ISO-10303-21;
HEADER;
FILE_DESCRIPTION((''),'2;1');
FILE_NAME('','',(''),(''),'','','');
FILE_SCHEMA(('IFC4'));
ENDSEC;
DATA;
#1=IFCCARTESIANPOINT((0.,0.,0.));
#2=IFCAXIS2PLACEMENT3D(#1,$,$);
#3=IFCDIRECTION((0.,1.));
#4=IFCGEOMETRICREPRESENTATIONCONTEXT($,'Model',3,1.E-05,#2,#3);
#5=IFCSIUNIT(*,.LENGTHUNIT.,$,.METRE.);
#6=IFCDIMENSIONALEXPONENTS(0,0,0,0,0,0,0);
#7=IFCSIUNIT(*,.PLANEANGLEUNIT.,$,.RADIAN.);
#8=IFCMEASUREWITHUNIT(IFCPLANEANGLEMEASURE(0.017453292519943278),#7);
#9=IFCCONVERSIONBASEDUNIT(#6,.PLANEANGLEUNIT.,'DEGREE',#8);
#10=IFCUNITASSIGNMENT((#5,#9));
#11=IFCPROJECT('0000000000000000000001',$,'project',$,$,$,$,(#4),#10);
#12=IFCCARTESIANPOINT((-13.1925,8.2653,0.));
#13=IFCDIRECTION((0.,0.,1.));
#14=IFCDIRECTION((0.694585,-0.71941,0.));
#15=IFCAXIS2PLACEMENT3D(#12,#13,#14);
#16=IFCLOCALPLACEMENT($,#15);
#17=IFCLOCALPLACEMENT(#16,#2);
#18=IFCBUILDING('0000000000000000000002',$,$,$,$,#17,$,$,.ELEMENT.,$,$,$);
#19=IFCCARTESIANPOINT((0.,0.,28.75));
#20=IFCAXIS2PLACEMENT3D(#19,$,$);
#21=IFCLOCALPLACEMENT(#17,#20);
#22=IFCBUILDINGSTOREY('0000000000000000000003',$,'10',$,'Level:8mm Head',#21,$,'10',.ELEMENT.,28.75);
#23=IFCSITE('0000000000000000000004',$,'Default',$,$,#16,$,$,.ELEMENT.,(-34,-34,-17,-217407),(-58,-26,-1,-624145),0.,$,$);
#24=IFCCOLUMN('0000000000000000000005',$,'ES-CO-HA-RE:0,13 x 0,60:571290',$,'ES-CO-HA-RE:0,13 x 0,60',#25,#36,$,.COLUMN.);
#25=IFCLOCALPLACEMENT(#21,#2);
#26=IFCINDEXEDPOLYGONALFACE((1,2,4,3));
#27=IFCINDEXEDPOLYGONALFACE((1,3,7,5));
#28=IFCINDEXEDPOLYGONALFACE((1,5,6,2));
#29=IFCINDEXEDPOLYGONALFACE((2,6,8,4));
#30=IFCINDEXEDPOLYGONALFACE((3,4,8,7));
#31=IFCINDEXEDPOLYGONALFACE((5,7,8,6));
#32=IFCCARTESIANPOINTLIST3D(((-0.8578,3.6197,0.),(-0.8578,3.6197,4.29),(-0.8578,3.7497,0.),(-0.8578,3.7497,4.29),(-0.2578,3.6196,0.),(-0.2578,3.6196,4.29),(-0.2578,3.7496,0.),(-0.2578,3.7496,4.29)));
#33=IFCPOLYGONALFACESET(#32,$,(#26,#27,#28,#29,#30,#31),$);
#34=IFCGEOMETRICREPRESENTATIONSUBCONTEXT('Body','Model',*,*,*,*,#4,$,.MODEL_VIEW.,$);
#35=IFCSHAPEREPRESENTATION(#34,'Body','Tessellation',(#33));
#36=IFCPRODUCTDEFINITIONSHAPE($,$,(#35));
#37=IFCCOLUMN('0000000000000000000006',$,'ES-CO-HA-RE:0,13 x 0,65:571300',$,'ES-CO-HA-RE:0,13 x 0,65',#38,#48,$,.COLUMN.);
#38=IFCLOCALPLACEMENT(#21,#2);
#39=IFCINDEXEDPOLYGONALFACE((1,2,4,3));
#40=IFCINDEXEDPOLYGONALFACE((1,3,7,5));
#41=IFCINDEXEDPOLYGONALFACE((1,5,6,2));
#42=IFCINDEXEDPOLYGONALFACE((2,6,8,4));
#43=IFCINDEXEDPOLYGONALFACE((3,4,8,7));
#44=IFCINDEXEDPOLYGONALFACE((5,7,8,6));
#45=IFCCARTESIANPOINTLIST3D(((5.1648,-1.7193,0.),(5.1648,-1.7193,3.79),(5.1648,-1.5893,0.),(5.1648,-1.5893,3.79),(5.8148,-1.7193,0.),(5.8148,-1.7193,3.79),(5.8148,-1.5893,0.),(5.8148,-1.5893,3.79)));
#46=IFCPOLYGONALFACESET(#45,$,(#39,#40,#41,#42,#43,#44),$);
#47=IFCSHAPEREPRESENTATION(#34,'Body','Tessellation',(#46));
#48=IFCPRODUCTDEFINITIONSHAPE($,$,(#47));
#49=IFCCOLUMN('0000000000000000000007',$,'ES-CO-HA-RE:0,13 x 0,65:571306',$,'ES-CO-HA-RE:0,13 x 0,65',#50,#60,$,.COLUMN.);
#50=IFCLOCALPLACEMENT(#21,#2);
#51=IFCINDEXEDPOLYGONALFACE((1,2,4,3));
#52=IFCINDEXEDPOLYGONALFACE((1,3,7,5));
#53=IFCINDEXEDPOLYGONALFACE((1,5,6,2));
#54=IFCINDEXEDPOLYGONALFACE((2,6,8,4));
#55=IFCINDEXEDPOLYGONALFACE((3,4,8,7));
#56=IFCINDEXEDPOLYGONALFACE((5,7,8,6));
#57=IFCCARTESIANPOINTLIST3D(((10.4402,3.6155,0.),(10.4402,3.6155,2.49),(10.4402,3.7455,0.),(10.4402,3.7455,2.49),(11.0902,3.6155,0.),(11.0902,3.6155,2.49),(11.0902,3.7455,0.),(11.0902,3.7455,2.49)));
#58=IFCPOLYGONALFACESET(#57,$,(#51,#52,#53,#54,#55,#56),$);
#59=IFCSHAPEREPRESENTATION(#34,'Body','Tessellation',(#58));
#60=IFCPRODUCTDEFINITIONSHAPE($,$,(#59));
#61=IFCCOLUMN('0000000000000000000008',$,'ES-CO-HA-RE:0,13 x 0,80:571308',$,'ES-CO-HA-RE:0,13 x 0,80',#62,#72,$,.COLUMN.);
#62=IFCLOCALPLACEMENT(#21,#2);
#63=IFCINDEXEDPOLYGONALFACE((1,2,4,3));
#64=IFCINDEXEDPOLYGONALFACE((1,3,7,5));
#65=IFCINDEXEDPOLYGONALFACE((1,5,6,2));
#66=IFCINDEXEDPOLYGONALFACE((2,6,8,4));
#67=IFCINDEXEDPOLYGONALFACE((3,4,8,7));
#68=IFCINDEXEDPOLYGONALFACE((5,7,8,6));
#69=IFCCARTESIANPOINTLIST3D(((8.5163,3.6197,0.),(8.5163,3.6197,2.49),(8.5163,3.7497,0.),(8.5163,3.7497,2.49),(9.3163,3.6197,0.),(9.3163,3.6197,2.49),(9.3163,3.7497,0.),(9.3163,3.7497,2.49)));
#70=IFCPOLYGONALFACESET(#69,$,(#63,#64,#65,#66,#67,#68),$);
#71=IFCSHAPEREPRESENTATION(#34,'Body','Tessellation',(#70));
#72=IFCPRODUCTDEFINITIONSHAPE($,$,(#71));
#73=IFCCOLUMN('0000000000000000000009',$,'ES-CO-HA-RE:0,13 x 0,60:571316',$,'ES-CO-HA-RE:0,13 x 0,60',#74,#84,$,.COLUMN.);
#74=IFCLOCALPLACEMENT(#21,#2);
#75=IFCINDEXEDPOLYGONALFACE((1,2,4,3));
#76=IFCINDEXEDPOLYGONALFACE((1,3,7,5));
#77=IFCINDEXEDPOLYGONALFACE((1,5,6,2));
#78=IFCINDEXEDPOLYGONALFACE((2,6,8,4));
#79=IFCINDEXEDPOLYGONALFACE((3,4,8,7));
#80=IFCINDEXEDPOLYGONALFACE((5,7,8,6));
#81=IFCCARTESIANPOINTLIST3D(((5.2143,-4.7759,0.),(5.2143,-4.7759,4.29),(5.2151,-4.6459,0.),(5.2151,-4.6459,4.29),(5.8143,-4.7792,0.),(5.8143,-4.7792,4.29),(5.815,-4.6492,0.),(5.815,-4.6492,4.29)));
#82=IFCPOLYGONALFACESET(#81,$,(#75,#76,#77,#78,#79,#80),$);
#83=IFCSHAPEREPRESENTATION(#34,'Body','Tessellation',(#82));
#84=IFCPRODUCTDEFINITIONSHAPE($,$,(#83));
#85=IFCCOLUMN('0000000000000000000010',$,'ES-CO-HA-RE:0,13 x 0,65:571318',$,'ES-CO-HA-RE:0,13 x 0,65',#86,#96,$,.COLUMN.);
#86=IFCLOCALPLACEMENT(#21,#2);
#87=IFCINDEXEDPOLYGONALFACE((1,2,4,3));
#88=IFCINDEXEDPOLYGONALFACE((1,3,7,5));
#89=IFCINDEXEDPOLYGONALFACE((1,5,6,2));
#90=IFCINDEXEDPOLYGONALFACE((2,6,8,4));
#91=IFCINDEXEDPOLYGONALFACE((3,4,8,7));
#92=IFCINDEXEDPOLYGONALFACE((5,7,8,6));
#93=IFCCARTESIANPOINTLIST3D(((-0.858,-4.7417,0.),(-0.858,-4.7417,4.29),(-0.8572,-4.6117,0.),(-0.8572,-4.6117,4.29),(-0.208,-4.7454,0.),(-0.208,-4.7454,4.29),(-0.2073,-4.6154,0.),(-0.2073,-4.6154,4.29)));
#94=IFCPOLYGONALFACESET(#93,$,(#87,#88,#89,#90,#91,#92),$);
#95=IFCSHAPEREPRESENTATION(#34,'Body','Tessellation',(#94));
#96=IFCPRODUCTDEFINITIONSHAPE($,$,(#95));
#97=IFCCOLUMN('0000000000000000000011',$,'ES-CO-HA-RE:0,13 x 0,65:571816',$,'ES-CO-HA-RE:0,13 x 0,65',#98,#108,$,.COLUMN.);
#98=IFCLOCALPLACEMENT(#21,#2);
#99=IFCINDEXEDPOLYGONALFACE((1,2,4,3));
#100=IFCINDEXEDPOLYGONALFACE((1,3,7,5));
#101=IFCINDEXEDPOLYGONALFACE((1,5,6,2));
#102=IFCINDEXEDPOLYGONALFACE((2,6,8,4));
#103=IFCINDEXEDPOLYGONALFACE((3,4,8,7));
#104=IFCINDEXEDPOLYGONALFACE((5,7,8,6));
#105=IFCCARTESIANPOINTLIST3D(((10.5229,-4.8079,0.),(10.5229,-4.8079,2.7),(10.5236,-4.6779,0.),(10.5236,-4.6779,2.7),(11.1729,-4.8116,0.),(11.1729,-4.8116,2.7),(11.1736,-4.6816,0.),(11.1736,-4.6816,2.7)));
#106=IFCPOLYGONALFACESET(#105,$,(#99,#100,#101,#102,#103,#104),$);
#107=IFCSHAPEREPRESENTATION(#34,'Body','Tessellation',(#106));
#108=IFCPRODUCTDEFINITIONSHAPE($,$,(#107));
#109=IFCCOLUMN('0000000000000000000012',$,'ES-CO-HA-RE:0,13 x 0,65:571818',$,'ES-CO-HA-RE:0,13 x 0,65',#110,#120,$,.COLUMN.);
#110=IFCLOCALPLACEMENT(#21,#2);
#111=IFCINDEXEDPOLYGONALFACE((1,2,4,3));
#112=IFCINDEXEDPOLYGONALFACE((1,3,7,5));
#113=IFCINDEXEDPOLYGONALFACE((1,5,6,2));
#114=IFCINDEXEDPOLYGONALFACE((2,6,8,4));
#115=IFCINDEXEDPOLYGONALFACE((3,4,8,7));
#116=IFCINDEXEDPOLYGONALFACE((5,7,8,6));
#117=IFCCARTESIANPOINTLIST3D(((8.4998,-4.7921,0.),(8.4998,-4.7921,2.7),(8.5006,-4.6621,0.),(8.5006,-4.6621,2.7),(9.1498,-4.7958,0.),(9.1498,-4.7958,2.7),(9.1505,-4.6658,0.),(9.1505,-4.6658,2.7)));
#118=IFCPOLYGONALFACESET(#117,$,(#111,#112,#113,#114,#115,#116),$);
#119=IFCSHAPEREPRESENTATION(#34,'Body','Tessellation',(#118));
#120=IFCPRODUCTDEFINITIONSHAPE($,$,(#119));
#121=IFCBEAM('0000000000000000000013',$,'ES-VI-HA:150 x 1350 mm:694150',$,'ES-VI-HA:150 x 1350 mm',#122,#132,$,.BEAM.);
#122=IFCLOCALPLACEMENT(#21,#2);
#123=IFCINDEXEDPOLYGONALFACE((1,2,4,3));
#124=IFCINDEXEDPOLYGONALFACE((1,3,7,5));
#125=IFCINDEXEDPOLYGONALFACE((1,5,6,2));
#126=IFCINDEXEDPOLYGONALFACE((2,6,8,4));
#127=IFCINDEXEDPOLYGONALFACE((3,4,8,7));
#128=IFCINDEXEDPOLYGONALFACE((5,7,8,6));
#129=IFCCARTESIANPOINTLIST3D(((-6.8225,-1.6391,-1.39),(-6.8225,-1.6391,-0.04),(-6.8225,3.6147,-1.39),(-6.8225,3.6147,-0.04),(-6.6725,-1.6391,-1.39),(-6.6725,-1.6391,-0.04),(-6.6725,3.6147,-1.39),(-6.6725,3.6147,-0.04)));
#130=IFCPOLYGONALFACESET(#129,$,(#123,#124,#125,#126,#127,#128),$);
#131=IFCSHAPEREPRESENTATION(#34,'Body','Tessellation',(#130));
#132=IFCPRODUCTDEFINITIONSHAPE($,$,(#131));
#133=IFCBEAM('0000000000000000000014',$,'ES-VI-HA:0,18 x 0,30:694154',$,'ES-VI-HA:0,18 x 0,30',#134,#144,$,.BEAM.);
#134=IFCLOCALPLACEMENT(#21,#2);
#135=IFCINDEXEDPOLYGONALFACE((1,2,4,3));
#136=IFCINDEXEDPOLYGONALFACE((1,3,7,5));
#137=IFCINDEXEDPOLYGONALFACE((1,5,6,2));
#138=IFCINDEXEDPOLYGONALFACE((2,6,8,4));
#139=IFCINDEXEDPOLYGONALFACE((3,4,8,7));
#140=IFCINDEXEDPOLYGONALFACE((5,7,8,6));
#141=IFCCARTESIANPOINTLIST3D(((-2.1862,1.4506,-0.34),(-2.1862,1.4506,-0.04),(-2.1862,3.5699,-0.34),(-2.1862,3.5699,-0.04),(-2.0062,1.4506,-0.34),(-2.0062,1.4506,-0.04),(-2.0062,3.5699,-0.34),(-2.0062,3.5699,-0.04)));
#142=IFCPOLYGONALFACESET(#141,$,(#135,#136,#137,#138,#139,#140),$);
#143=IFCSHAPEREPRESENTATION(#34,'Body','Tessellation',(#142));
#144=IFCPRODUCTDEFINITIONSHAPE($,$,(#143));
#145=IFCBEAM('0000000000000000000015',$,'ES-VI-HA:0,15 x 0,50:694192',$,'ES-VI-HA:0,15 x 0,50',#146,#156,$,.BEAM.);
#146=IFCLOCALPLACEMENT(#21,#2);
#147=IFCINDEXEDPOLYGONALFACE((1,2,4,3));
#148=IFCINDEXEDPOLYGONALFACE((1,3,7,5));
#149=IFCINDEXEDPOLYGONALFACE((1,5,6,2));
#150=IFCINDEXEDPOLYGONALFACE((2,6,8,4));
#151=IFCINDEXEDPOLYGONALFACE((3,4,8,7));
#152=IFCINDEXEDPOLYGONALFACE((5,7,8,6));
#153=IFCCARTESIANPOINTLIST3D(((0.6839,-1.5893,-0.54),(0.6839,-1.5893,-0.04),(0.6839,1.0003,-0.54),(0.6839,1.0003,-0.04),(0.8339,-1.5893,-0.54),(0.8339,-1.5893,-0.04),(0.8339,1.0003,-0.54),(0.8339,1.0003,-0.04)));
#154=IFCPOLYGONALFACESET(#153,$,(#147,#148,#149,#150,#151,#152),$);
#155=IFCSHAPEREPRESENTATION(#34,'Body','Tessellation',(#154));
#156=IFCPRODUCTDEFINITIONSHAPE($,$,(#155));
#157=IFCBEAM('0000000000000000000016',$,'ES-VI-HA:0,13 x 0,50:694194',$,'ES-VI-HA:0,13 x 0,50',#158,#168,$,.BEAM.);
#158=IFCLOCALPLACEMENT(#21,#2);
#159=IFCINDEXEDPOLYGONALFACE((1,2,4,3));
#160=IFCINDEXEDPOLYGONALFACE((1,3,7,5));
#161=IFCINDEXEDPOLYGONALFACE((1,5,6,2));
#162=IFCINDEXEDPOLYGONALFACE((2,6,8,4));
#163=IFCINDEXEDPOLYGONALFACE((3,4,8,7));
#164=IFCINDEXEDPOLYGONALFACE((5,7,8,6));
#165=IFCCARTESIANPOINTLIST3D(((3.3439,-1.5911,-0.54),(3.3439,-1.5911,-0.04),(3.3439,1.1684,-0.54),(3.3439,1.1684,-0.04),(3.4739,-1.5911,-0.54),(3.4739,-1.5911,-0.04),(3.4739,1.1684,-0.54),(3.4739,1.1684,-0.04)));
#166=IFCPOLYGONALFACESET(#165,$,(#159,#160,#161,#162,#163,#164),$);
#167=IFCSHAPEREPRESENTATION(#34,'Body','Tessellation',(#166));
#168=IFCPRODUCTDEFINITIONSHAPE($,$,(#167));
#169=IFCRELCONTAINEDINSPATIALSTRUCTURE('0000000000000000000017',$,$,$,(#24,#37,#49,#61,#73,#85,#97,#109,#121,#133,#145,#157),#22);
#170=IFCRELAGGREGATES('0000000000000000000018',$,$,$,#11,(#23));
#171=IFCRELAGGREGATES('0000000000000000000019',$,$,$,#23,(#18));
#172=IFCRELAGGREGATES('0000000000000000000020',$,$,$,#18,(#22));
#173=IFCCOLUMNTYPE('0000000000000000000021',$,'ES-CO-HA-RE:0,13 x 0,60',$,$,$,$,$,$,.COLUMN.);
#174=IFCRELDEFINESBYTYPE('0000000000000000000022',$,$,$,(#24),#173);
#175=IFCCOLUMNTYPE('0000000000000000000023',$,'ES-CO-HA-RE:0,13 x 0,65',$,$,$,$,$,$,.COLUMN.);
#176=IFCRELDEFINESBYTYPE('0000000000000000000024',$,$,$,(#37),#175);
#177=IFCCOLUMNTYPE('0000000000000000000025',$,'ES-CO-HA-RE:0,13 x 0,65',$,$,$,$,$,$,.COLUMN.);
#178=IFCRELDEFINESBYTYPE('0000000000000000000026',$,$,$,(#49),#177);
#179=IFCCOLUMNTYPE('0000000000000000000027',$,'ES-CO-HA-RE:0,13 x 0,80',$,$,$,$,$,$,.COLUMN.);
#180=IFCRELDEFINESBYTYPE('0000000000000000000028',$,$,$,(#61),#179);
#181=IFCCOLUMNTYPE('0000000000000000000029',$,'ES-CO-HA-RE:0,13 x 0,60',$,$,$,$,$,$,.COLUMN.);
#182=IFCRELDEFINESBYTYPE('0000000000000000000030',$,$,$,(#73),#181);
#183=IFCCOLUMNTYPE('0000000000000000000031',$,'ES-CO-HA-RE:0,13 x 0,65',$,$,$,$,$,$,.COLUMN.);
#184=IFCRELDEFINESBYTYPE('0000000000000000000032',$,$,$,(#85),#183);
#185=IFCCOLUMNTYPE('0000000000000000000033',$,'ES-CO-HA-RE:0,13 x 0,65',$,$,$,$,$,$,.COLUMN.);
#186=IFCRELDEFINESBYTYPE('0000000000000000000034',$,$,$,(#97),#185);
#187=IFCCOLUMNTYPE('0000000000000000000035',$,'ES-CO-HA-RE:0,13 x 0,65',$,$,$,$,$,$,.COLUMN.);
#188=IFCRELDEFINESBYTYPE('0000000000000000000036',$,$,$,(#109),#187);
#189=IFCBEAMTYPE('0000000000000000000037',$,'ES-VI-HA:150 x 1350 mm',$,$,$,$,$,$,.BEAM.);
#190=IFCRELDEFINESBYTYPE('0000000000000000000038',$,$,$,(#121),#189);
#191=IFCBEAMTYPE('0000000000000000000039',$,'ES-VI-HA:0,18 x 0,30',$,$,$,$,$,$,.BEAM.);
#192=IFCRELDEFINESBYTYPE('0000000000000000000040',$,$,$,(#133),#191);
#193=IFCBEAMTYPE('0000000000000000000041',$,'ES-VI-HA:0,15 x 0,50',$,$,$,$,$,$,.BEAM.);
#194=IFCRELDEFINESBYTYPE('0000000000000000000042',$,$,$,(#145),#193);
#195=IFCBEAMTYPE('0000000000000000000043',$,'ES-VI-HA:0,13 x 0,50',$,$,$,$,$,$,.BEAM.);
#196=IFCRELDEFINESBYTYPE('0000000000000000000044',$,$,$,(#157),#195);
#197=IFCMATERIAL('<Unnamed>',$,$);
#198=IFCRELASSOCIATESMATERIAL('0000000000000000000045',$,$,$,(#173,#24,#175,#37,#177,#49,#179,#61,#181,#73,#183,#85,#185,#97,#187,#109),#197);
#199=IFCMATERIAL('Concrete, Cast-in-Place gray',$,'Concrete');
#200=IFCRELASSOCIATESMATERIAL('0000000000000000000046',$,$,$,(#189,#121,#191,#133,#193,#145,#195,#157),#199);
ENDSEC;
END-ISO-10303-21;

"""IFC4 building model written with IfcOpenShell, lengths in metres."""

from ifc_helpers import new_model, entity, si_unit, converted_unit, direction, frame, origin, place, context, subcontext, project, spatial, indexed_curve, outline, extrude, source, transform, mapped, material, type_object, type_shapes, element, save


model = new_model("IFC4")

# Units and contexts
model_context = context("Model", 3, precision=1e-05, world=origin(), true_north=direction((0.0, 1.0)))
body_context = subcontext(model_context, "Body", "Model", "MODEL_VIEW")
ifc_project = project(units=[si_unit("LENGTHUNIT", "METRE"), converted_unit("PLANEANGLEUNIT", "DEGREE", entity("IfcPlaneAngleMeasure", 0.017453292519943278), si_unit("PLANEANGLEUNIT", "RADIAN"), dimensions=[0, 0, 0, 0, 0, 0, 0])], contexts=[model_context])

# Site, building, storey
site_placement = place(None, frame((-13.1925, 8.2653, 0.0), z_axis=(0.0, 0.0, 1.0), x_axis=(0.694585, -0.71941, 0.0)))
site = spatial("IfcSite", under=ifc_project, at=site_placement, Name="Default", CompositionType="ELEMENT", RefLatitude=(-34, -34, -17, -217407), RefLongitude=(-58, -26, -1, -624145), RefElevation=0.0)
building_placement = place(site_placement, origin())
building = spatial("IfcBuilding", under=site, at=building_placement, CompositionType="ELEMENT")
storey_placement = place(building_placement, frame((0.0, 0.0, 28.75)))
storey = spatial("IfcBuildingStorey", under=building, at=storey_placement, Name="10", ObjectType="Level:8mm Head", LongName="10", CompositionType="ELEMENT", Elevation=28.75)

# Columns
ifc_material_1 = material(Name="<Unnamed>")
column_type_1 = type_object("IfcColumnType", Name="ES-CO-HA-RE:0,13 x 0,60", PredefinedType="COLUMN", material=ifc_material_1)
shared_shape_1 = source(origin(), body_context, "Body", "SweptSolid", [
    extrude(outline(indexed_curve([(-0.3, -0.065), (0.3, -0.065), (0.3, 0.065), (-0.3, 0.065), (-0.3, -0.065)], self_intersect=False)), frame((-0.5578, 3.6847, 28.75), z_axis=(0.0, 0.0, 1.0), x_axis=(-1.0, 0.000006, 0.0)), (0.0, 0.0, 1.0), 4.29),
])
type_shapes(column_type_1, [shared_shape_1])
column_1_placement = place(storey_placement, frame((0.0, 0.0, -28.75)))
element("IfcColumn", 1, at=column_1_placement, inside=storey, type_object=column_type_1, material=ifc_material_1, Name="ES-CO-HA-RE:0,13 x 0,60:571290", ObjectType="ES-CO-HA-RE:0,13 x 0,60", PredefinedType="COLUMN", context=body_context, shape_type="MappedRepresentation", body=[
    mapped(shared_shape_1, transform((0.0, 0.0, 0.0), scale=1.0)),
])
column_type_2 = type_object("IfcColumnType", Name="ES-CO-HA-RE:0,13 x 0,65", PredefinedType="COLUMN", material=ifc_material_1)
shared_shape_2 = source(origin(), body_context, "Body", "SweptSolid", [
    extrude(outline(indexed_curve([(-0.325, -0.065), (0.325, -0.065), (0.325, 0.065), (-0.325, 0.065), (-0.325, -0.065)], self_intersect=False)), frame((5.4898, -1.6543, 28.75), z_axis=(0.0, 0.0, 1.0), x_axis=(-1.0, 0.0, 0.0)), (0.0, 0.0, 1.0), 3.79),
])
type_shapes(column_type_2, [shared_shape_2])
column_2_placement = place(storey_placement, frame((0.0, 0.0, -28.75)))
element("IfcColumn", 2, at=column_2_placement, inside=storey, type_object=column_type_2, material=ifc_material_1, Name="ES-CO-HA-RE:0,13 x 0,65:571300", ObjectType="ES-CO-HA-RE:0,13 x 0,65", PredefinedType="COLUMN", context=body_context, shape_type="MappedRepresentation", body=[
    mapped(shared_shape_2, transform((0.0, 0.0, 0.0), scale=1.0)),
])
column_type_3 = type_object("IfcColumnType", Name="ES-CO-HA-RE:0,13 x 0,65", PredefinedType="COLUMN", material=ifc_material_1)
shared_shape_3 = source(origin(), body_context, "Body", "SweptSolid", [
    extrude(outline(indexed_curve([(-0.325, -0.065), (0.325, -0.065), (0.325, 0.065), (-0.325, 0.065), (-0.325, -0.065)], self_intersect=False)), frame((10.7652, 3.6805, 28.75), z_axis=(0.0, 0.0, 1.0), x_axis=(-1.0, 0.0, 0.0)), (0.0, 0.0, 1.0), 2.49),
])
type_shapes(column_type_3, [shared_shape_3])
column_3_placement = place(storey_placement, frame((0.0, 0.0, -28.75)))
element("IfcColumn", 3, at=column_3_placement, inside=storey, type_object=column_type_3, material=ifc_material_1, Name="ES-CO-HA-RE:0,13 x 0,65:571306", ObjectType="ES-CO-HA-RE:0,13 x 0,65", PredefinedType="COLUMN", context=body_context, shape_type="MappedRepresentation", body=[
    mapped(shared_shape_3, transform((0.0, 0.0, 0.0), scale=1.0)),
])
column_type_4 = type_object("IfcColumnType", Name="ES-CO-HA-RE:0,13 x 0,80", PredefinedType="COLUMN", material=ifc_material_1)
shared_shape_4 = source(origin(), body_context, "Body", "SweptSolid", [
    extrude(outline(indexed_curve([(-0.4, -0.065), (0.4, -0.065), (0.4, 0.065), (-0.4, 0.065), (-0.4, -0.065)], self_intersect=False)), frame((8.9163, 3.6847, 28.75), z_axis=(0.0, 0.0, 1.0), x_axis=(-1.0, 0.0, 0.0)), (0.0, 0.0, 1.0), 2.49),
])
type_shapes(column_type_4, [shared_shape_4])
column_4_placement = place(storey_placement, frame((0.0, 0.0, -28.75)))
element("IfcColumn", 4, at=column_4_placement, inside=storey, type_object=column_type_4, material=ifc_material_1, Name="ES-CO-HA-RE:0,13 x 0,80:571308", ObjectType="ES-CO-HA-RE:0,13 x 0,80", PredefinedType="COLUMN", context=body_context, shape_type="MappedRepresentation", body=[
    mapped(shared_shape_4, transform((0.0, 0.0, 0.0), scale=1.0)),
])
column_type_5 = type_object("IfcColumnType", Name="ES-CO-HA-RE:0,13 x 0,60", PredefinedType="COLUMN", material=ifc_material_1)
shared_shape_5 = source(origin(), body_context, "Body", "SweptSolid", [
    extrude(outline(indexed_curve([(-0.3, -0.065), (0.3, -0.065), (0.3, 0.065), (-0.3, 0.065), (-0.3, -0.065)], self_intersect=False)), frame((5.5147, -4.7125, 28.75), z_axis=(0.0, 0.0, 1.0), x_axis=(-0.999984, 0.005619, 0.0)), (0.0, 0.0, 1.0), 4.29),
])
type_shapes(column_type_5, [shared_shape_5])
column_5_placement = place(storey_placement, frame((0.0, 0.0, -28.75)))
element("IfcColumn", 5, at=column_5_placement, inside=storey, type_object=column_type_5, material=ifc_material_1, Name="ES-CO-HA-RE:0,13 x 0,60:571316", ObjectType="ES-CO-HA-RE:0,13 x 0,60", PredefinedType="COLUMN", context=body_context, shape_type="MappedRepresentation", body=[
    mapped(shared_shape_5, transform((0.0, 0.0, 0.0), scale=1.0)),
])
column_type_6 = type_object("IfcColumnType", Name="ES-CO-HA-RE:0,13 x 0,65", PredefinedType="COLUMN", material=ifc_material_1)
shared_shape_6 = source(origin(), body_context, "Body", "SweptSolid", [
    extrude(outline(indexed_curve([(-0.325, -0.065), (0.325, -0.065), (0.325, 0.065), (-0.325, 0.065), (-0.325, -0.065)], self_intersect=False)), frame((-0.5326, -4.6786, 28.75), z_axis=(0.0, 0.0, 1.0), x_axis=(-0.999984, 0.005617, 0.0)), (0.0, 0.0, 1.0), 4.29),
])
type_shapes(column_type_6, [shared_shape_6])
column_6_placement = place(storey_placement, frame((0.0, 0.0, -28.75)))
element("IfcColumn", 6, at=column_6_placement, inside=storey, type_object=column_type_6, material=ifc_material_1, Name="ES-CO-HA-RE:0,13 x 0,65:571318", ObjectType="ES-CO-HA-RE:0,13 x 0,65", PredefinedType="COLUMN", context=body_context, shape_type="MappedRepresentation", body=[
    mapped(shared_shape_6, transform((0.0, 0.0, 0.0), scale=1.0)),
])
column_type_7 = type_object("IfcColumnType", Name="ES-CO-HA-RE:0,13 x 0,65", PredefinedType="COLUMN", material=ifc_material_1)
shared_shape_7 = source(origin(), body_context, "Body", "SweptSolid", [
    extrude(outline(indexed_curve([(-0.325, -0.065), (0.325, -0.065), (0.325, 0.065), (-0.325, 0.065), (-0.325, -0.065)], self_intersect=False)), frame((10.8483, -4.7447, 28.75), z_axis=(0.0, 0.0, 1.0), x_axis=(-0.999984, 0.005619, 0.0)), (0.0, 0.0, 1.0), 2.7),
])
type_shapes(column_type_7, [shared_shape_7])
column_7_placement = place(storey_placement, frame((0.0, 0.0, -28.75)))
element("IfcColumn", 7, at=column_7_placement, inside=storey, type_object=column_type_7, material=ifc_material_1, Name="ES-CO-HA-RE:0,13 x 0,65:571816", ObjectType="ES-CO-HA-RE:0,13 x 0,65", PredefinedType="COLUMN", context=body_context, shape_type="MappedRepresentation", body=[
    mapped(shared_shape_7, transform((0.0, 0.0, 0.0), scale=1.0)),
])
column_type_8 = type_object("IfcColumnType", Name="ES-CO-HA-RE:0,13 x 0,65", PredefinedType="COLUMN", material=ifc_material_1)
shared_shape_8 = source(origin(), body_context, "Body", "SweptSolid", [
    extrude(outline(indexed_curve([(-0.325, -0.065), (0.325, -0.065), (0.325, 0.065), (-0.325, 0.065), (-0.325, -0.065)], self_intersect=False)), frame((8.8252, -4.7289, 28.75), z_axis=(0.0, 0.0, 1.0), x_axis=(-0.999984, 0.005619, 0.0)), (0.0, 0.0, 1.0), 2.7),
])
type_shapes(column_type_8, [shared_shape_8])
column_8_placement = place(storey_placement, frame((0.0, 0.0, -28.75)))
element("IfcColumn", 8, at=column_8_placement, inside=storey, type_object=column_type_8, material=ifc_material_1, Name="ES-CO-HA-RE:0,13 x 0,65:571818", ObjectType="ES-CO-HA-RE:0,13 x 0,65", PredefinedType="COLUMN", context=body_context, shape_type="MappedRepresentation", body=[
    mapped(shared_shape_8, transform((0.0, 0.0, 0.0), scale=1.0)),
])

# Beams
ifc_material_2 = material(Name="Concrete, Cast-in-Place gray", Category="Concrete")
beam_type_1 = type_object("IfcBeamType", Name="ES-VI-HA:150 x 1350 mm", PredefinedType="BEAM", material=ifc_material_2)
shared_shape_9 = source(origin(), body_context, "Body", "SweptSolid", [
    extrude(outline(indexed_curve([(-0.075, -0.675), (0.075, -0.675), (0.075, 0.675), (-0.075, 0.675), (-0.075, -0.675)], self_intersect=False)), frame((-6.7475, -1.6391, 28.035), z_axis=(0.0, 1.0, 0.0), x_axis=(-1.0, 0.0, 0.0)), (0.0, 0.0, 1.0), 5.2537),
])
type_shapes(beam_type_1, [shared_shape_9])
beam_1_placement = place(storey_placement, frame((0.0, 0.0, -28.75)))
element("IfcBeam", 9, at=beam_1_placement, inside=storey, type_object=beam_type_1, material=ifc_material_2, Name="ES-VI-HA:150 x 1350 mm:694150", ObjectType="ES-VI-HA:150 x 1350 mm", PredefinedType="BEAM", context=body_context, shape_type="MappedRepresentation", body=[
    mapped(shared_shape_9, transform((0.0, 0.0, 0.0), scale=1.0)),
])
beam_type_2 = type_object("IfcBeamType", Name="ES-VI-HA:0,18 x 0,30", PredefinedType="BEAM", material=ifc_material_2)
shared_shape_10 = source(origin(), body_context, "Body", "SweptSolid", [
    extrude(outline(indexed_curve([(-0.09, -0.15), (0.09, -0.15), (0.09, 0.15), (-0.09, 0.15), (-0.09, -0.15)], self_intersect=False)), frame((-2.0962, 3.5699, 28.56), z_axis=(0.0, -1.0, 0.0), x_axis=(-1.0, 0.0, 0.0)), (0.0, 0.0, 1.0), 2.1193),
])
type_shapes(beam_type_2, [shared_shape_10])
beam_2_placement = place(storey_placement, frame((0.0, 0.0, -28.75)))
element("IfcBeam", 10, at=beam_2_placement, inside=storey, type_object=beam_type_2, material=ifc_material_2, Name="ES-VI-HA:0,18 x 0,30:694154", ObjectType="ES-VI-HA:0,18 x 0,30", PredefinedType="BEAM", context=body_context, shape_type="MappedRepresentation", body=[
    mapped(shared_shape_10, transform((0.0, 0.0, 0.0), scale=1.0)),
])
beam_type_3 = type_object("IfcBeamType", Name="ES-VI-HA:0,15 x 0,50", PredefinedType="BEAM", material=ifc_material_2)
shared_shape_11 = source(origin(), body_context, "Body", "SweptSolid", [
    extrude(outline(indexed_curve([(-0.075, -0.25), (0.075, -0.25), (0.075, 0.25), (-0.075, 0.25), (-0.075, -0.25)], self_intersect=False)), frame((0.7589, -1.5893, 28.46), z_axis=(0.0, 1.0, 0.0), x_axis=(-1.0, 0.0, 0.0)), (0.0, 0.0, 1.0), 2.5896),
])
type_shapes(beam_type_3, [shared_shape_11])
beam_3_placement = place(storey_placement, frame((0.0, 0.0, -28.75)))
element("IfcBeam", 11, at=beam_3_placement, inside=storey, type_object=beam_type_3, material=ifc_material_2, Name="ES-VI-HA:0,15 x 0,50:694192", ObjectType="ES-VI-HA:0,15 x 0,50", PredefinedType="BEAM", context=body_context, shape_type="MappedRepresentation", body=[
    mapped(shared_shape_11, transform((0.0, 0.0, 0.0), scale=1.0)),
])
beam_type_4 = type_object("IfcBeamType", Name="ES-VI-HA:0,13 x 0,50", PredefinedType="BEAM", material=ifc_material_2)
shared_shape_12 = source(origin(), body_context, "Body", "SweptSolid", [
    extrude(outline(indexed_curve([(-0.065, -0.25), (0.065, -0.25), (0.065, 0.25), (-0.065, 0.25), (-0.065, -0.25)], self_intersect=False)), frame((3.4089, -1.5911, 28.46), z_axis=(0.0, 1.0, 0.0), x_axis=(-1.0, 0.0, 0.0)), (0.0, 0.0, 1.0), 2.7595),
])
type_shapes(beam_type_4, [shared_shape_12])
beam_4_placement = place(storey_placement, frame((0.0, 0.0, -28.75)))
element("IfcBeam", 12, at=beam_4_placement, inside=storey, type_object=beam_type_4, material=ifc_material_2, Name="ES-VI-HA:0,13 x 0,50:694194", ObjectType="ES-VI-HA:0,13 x 0,50", PredefinedType="BEAM", context=body_context, shape_type="MappedRepresentation", body=[
    mapped(shared_shape_12, transform((0.0, 0.0, 0.0), scale=1.0)),
])

save(model, "model.ifc")
